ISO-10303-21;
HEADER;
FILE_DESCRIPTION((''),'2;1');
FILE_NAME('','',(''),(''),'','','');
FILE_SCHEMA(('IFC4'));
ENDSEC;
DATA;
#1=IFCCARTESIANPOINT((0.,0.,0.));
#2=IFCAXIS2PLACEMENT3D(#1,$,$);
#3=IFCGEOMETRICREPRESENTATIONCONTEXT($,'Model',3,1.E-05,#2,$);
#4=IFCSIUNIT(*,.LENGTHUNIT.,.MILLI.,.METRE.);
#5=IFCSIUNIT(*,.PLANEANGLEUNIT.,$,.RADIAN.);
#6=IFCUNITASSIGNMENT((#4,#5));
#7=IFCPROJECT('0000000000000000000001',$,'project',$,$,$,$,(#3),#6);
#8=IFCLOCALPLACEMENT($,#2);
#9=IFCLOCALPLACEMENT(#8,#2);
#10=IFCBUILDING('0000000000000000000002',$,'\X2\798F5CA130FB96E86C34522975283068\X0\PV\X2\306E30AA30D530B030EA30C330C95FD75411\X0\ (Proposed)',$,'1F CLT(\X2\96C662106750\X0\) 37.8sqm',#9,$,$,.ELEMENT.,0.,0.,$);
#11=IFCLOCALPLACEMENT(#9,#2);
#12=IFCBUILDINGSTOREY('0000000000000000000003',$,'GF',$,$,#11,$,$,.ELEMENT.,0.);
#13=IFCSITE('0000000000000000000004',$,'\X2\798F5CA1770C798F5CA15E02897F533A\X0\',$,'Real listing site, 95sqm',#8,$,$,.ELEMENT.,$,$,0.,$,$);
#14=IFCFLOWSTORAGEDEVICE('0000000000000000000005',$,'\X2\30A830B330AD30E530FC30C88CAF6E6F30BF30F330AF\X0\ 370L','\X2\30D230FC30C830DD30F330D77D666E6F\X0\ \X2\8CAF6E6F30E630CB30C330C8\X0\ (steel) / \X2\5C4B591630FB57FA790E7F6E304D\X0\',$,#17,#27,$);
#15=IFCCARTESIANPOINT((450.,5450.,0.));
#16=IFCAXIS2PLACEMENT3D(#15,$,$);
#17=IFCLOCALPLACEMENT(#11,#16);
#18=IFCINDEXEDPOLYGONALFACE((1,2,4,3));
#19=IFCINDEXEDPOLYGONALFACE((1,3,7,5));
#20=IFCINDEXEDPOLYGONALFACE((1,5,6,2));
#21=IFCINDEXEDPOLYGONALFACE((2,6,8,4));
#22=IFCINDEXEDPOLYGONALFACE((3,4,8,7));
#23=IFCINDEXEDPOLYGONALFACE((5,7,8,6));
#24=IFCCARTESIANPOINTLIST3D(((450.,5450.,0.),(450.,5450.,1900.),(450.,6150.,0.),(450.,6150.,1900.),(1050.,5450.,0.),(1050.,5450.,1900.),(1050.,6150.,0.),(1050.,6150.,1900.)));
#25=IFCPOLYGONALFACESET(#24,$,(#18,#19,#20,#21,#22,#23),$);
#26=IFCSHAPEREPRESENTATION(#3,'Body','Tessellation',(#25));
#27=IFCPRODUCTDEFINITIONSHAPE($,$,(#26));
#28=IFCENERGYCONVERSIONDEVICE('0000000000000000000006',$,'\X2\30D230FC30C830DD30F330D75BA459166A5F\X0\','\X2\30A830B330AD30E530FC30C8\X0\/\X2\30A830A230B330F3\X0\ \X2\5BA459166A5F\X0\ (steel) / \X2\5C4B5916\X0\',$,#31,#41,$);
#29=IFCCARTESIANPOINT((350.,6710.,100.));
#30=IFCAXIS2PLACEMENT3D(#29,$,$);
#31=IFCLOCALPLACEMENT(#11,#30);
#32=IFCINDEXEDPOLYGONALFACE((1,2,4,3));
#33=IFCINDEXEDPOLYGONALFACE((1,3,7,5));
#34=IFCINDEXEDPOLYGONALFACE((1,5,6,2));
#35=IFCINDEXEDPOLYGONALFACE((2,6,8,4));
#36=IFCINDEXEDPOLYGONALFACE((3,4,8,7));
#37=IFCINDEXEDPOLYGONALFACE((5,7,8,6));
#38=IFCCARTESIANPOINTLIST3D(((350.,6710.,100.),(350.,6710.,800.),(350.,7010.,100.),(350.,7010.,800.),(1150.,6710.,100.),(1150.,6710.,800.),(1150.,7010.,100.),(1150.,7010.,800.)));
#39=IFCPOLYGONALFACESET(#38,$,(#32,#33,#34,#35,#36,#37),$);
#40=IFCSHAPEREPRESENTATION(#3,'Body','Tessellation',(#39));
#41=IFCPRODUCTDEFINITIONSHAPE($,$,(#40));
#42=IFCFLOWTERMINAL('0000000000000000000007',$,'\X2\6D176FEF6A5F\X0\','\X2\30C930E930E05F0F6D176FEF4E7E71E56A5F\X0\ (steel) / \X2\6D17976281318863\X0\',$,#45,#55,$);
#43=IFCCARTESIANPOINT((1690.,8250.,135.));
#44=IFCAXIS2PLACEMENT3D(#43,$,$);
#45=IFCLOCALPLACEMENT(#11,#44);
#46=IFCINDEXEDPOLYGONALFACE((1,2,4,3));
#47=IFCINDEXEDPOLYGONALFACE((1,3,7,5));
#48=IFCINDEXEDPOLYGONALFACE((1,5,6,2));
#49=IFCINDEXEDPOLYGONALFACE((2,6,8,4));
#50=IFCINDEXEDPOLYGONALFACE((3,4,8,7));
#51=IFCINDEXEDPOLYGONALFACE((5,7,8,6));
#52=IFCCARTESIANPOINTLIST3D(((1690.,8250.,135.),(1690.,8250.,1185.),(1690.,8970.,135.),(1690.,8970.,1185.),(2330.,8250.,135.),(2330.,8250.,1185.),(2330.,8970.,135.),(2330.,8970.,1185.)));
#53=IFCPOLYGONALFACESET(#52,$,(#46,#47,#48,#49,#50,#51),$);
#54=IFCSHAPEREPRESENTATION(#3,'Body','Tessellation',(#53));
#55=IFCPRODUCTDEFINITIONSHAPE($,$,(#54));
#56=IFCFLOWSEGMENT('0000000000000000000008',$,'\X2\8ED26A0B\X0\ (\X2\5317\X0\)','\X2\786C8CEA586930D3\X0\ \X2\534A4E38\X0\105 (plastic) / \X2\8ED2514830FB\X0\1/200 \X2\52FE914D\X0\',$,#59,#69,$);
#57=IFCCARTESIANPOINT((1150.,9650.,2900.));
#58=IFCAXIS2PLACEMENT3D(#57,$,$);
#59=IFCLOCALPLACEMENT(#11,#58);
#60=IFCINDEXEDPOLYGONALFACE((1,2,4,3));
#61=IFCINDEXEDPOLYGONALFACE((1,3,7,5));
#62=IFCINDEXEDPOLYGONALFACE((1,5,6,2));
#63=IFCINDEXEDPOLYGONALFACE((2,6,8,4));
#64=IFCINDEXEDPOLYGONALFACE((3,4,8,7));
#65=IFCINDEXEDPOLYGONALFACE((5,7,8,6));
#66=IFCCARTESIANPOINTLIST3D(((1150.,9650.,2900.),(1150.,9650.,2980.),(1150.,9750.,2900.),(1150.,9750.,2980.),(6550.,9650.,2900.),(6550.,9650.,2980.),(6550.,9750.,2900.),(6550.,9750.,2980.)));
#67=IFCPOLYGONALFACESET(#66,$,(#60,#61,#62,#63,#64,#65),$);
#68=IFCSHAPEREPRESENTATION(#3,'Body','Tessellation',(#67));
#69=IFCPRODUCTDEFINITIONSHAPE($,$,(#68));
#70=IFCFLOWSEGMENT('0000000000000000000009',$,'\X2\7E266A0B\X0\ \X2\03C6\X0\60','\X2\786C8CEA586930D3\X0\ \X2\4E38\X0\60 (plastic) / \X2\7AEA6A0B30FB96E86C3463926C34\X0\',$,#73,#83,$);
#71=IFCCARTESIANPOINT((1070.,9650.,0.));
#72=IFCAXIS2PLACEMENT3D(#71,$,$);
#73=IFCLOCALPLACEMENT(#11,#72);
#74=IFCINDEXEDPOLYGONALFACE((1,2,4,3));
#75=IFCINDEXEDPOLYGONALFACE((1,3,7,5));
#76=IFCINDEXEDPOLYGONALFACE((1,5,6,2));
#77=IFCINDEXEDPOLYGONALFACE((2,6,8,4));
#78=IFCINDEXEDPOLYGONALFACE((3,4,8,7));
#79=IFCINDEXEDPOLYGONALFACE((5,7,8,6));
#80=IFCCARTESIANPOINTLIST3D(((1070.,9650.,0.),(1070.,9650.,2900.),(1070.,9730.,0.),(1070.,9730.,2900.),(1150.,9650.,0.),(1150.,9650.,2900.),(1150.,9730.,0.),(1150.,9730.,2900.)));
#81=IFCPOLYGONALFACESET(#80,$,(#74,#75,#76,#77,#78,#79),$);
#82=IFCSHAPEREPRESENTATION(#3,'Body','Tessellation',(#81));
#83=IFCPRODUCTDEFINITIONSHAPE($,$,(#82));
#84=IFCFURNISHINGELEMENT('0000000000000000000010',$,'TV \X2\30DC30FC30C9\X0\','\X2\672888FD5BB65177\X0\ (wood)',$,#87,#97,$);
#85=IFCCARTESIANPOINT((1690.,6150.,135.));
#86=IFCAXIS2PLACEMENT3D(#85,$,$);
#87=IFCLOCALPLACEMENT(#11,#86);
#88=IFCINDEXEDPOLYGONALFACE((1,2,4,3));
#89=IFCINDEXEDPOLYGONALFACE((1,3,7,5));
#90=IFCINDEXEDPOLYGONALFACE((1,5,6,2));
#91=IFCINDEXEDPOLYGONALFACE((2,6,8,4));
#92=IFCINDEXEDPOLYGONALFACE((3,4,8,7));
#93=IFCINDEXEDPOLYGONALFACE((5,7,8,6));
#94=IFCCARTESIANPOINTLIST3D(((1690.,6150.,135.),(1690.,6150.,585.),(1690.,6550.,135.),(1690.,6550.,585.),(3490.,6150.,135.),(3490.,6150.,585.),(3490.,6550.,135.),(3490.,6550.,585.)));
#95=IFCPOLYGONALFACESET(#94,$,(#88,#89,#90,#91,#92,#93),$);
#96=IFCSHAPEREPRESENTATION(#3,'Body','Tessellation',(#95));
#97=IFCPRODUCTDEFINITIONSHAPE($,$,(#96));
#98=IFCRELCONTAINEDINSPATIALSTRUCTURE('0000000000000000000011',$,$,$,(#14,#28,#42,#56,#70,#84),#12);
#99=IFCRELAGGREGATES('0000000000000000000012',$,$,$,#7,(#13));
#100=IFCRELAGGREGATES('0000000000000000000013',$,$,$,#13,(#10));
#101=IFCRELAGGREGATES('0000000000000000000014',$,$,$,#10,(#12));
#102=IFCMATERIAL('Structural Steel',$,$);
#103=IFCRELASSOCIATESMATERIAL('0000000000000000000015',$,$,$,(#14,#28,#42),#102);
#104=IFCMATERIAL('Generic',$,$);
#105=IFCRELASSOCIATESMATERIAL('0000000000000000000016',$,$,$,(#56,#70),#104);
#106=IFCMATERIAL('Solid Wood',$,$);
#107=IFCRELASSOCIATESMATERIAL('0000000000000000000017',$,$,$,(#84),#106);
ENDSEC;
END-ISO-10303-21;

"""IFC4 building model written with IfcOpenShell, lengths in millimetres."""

from ifc_helpers import new_model, si_unit, frame, frame_2d, origin, place, context, project, spatial, rectangle, extrude, material, element, save


model = new_model("IFC4")

# Units and contexts
model_context = context("Model", 3, precision=1e-05, world=origin())
ifc_project = project(units=[si_unit("LENGTHUNIT", "METRE", prefix="MILLI"), si_unit("PLANEANGLEUNIT", "RADIAN")], contexts=[model_context])

# Site, building, storey
site_placement = place(None, origin())
site = spatial("IfcSite", under=ifc_project, at=site_placement, Name="福岡県福岡市西区", ObjectType="Real listing site, 95sqm", CompositionType="ELEMENT", RefElevation=0.0)
building_placement = place(site_placement, origin())
building = spatial("IfcBuilding", under=site, at=building_placement, Name="福岡・雨水利用とPVのオフグリッド志向 (Proposed)", ObjectType="1F CLT(集成材) 37.8sqm", CompositionType="ELEMENT", ElevationOfRefHeight=0.0, ElevationOfTerrain=0.0)
storey_placement = place(building_placement, origin())
storey = spatial("IfcBuildingStorey", under=building, at=storey_placement, Name="GF", CompositionType="ELEMENT", Elevation=0.0)

# Shared definitions
ifc_material_1 = material(Name="Solid Wood")

# Shared definitions
ifc_material_2 = material(Name="Structural Steel")

# Shared definitions
ifc_material_3 = material(Name="Generic")

# Flow storage device
flow_storage_device_placement = place(storey_placement, frame((450.0, 5450.0, 0.0)))
element("IfcFlowStorageDevice", 1, at=flow_storage_device_placement, inside=storey, material=ifc_material_2, Name="エコキュート貯湯タンク 370L", Description="ヒートポンプ給湯 貯湯ユニット (steel) / 屋外・基礎置き", context=model_context, shape_type="SweptSolid", body=[
    extrude(rectangle(XDim=600.0, YDim=700.0, at=frame_2d((300.0, 350.0))), frame((450.0, 5450.0, 0.0)), (0.0, 0.0, 1.0), 1900.0),
])

# Energy conversion device
energy_conversion_device_placement = place(storey_placement, frame((350.0, 6710.0, 100.0)))
element("IfcEnergyConversionDevice", 2, at=energy_conversion_device_placement, inside=storey, material=ifc_material_2, Name="ヒートポンプ室外機", Description="エコキュート/エアコン 室外機 (steel) / 屋外", context=model_context, shape_type="SweptSolid", body=[
    extrude(rectangle(XDim=800.0, YDim=300.0, at=frame_2d((400.0, 150.0))), frame((350.0, 6710.0, 100.0)), (0.0, 0.0, 1.0), 700.0),
])

# Flow terminal
flow_terminal_placement = place(storey_placement, frame((1690.0, 8250.0, 135.0)))
element("IfcFlowTerminal", 3, at=flow_terminal_placement, inside=storey, material=ifc_material_2, Name="洗濯機", Description="ドラム式洗濯乾燥機 (steel) / 洗面脱衣", context=model_context, shape_type="SweptSolid", body=[
    extrude(rectangle(XDim=640.0, YDim=720.0, at=frame_2d((320.0, 360.0))), frame((1690.0, 8250.0, 135.0)), (0.0, 0.0, 1.0), 1050.0),
])

# Flow segments
flow_segment_1_placement = place(storey_placement, frame((1150.0, 9650.0, 2900.0)))
element("IfcFlowSegment", 4, at=flow_segment_1_placement, inside=storey, material=ifc_material_3, Name="軒樋 (北)", Description="硬質塩ビ 半丸105 (plastic) / 軒先・1/200 勾配", context=model_context, shape_type="SweptSolid", body=[
    extrude(rectangle(XDim=5400.0, YDim=100.0, at=frame_2d((2700.0, 50.0))), frame((1150.0, 9650.0, 2900.0)), (0.0, 0.0, 1.0), 80.0),
])
flow_segment_2_placement = place(storey_placement, frame((1070.0, 9650.0, 0.0)))
element("IfcFlowSegment", 5, at=flow_segment_2_placement, inside=storey, material=ifc_material_3, Name="縦樋 φ60", Description="硬質塩ビ 丸60 (plastic) / 竪樋・雨水排水", context=model_context, shape_type="SweptSolid", body=[
    extrude(rectangle(XDim=80.0, YDim=80.0, at=frame_2d((40.0, 40.0))), frame((1070.0, 9650.0, 0.0)), (0.0, 0.0, 1.0), 2900.0),
])

# Furnishing element
furnishing_placement = place(storey_placement, frame((1690.0, 6150.0, 135.0)))
element("IfcFurnishingElement", 6, at=furnishing_placement, inside=storey, material=ifc_material_1, Name="TV ボード", Description="木製家具 (wood)", context=model_context, shape_type="SweptSolid", body=[
    extrude(rectangle(XDim=1800.0, YDim=400.0, at=frame_2d((900.0, 200.0))), frame((1690.0, 6150.0, 135.0)), (0.0, 0.0, 1.0), 450.0),
])

save(model, "model.ifc")
